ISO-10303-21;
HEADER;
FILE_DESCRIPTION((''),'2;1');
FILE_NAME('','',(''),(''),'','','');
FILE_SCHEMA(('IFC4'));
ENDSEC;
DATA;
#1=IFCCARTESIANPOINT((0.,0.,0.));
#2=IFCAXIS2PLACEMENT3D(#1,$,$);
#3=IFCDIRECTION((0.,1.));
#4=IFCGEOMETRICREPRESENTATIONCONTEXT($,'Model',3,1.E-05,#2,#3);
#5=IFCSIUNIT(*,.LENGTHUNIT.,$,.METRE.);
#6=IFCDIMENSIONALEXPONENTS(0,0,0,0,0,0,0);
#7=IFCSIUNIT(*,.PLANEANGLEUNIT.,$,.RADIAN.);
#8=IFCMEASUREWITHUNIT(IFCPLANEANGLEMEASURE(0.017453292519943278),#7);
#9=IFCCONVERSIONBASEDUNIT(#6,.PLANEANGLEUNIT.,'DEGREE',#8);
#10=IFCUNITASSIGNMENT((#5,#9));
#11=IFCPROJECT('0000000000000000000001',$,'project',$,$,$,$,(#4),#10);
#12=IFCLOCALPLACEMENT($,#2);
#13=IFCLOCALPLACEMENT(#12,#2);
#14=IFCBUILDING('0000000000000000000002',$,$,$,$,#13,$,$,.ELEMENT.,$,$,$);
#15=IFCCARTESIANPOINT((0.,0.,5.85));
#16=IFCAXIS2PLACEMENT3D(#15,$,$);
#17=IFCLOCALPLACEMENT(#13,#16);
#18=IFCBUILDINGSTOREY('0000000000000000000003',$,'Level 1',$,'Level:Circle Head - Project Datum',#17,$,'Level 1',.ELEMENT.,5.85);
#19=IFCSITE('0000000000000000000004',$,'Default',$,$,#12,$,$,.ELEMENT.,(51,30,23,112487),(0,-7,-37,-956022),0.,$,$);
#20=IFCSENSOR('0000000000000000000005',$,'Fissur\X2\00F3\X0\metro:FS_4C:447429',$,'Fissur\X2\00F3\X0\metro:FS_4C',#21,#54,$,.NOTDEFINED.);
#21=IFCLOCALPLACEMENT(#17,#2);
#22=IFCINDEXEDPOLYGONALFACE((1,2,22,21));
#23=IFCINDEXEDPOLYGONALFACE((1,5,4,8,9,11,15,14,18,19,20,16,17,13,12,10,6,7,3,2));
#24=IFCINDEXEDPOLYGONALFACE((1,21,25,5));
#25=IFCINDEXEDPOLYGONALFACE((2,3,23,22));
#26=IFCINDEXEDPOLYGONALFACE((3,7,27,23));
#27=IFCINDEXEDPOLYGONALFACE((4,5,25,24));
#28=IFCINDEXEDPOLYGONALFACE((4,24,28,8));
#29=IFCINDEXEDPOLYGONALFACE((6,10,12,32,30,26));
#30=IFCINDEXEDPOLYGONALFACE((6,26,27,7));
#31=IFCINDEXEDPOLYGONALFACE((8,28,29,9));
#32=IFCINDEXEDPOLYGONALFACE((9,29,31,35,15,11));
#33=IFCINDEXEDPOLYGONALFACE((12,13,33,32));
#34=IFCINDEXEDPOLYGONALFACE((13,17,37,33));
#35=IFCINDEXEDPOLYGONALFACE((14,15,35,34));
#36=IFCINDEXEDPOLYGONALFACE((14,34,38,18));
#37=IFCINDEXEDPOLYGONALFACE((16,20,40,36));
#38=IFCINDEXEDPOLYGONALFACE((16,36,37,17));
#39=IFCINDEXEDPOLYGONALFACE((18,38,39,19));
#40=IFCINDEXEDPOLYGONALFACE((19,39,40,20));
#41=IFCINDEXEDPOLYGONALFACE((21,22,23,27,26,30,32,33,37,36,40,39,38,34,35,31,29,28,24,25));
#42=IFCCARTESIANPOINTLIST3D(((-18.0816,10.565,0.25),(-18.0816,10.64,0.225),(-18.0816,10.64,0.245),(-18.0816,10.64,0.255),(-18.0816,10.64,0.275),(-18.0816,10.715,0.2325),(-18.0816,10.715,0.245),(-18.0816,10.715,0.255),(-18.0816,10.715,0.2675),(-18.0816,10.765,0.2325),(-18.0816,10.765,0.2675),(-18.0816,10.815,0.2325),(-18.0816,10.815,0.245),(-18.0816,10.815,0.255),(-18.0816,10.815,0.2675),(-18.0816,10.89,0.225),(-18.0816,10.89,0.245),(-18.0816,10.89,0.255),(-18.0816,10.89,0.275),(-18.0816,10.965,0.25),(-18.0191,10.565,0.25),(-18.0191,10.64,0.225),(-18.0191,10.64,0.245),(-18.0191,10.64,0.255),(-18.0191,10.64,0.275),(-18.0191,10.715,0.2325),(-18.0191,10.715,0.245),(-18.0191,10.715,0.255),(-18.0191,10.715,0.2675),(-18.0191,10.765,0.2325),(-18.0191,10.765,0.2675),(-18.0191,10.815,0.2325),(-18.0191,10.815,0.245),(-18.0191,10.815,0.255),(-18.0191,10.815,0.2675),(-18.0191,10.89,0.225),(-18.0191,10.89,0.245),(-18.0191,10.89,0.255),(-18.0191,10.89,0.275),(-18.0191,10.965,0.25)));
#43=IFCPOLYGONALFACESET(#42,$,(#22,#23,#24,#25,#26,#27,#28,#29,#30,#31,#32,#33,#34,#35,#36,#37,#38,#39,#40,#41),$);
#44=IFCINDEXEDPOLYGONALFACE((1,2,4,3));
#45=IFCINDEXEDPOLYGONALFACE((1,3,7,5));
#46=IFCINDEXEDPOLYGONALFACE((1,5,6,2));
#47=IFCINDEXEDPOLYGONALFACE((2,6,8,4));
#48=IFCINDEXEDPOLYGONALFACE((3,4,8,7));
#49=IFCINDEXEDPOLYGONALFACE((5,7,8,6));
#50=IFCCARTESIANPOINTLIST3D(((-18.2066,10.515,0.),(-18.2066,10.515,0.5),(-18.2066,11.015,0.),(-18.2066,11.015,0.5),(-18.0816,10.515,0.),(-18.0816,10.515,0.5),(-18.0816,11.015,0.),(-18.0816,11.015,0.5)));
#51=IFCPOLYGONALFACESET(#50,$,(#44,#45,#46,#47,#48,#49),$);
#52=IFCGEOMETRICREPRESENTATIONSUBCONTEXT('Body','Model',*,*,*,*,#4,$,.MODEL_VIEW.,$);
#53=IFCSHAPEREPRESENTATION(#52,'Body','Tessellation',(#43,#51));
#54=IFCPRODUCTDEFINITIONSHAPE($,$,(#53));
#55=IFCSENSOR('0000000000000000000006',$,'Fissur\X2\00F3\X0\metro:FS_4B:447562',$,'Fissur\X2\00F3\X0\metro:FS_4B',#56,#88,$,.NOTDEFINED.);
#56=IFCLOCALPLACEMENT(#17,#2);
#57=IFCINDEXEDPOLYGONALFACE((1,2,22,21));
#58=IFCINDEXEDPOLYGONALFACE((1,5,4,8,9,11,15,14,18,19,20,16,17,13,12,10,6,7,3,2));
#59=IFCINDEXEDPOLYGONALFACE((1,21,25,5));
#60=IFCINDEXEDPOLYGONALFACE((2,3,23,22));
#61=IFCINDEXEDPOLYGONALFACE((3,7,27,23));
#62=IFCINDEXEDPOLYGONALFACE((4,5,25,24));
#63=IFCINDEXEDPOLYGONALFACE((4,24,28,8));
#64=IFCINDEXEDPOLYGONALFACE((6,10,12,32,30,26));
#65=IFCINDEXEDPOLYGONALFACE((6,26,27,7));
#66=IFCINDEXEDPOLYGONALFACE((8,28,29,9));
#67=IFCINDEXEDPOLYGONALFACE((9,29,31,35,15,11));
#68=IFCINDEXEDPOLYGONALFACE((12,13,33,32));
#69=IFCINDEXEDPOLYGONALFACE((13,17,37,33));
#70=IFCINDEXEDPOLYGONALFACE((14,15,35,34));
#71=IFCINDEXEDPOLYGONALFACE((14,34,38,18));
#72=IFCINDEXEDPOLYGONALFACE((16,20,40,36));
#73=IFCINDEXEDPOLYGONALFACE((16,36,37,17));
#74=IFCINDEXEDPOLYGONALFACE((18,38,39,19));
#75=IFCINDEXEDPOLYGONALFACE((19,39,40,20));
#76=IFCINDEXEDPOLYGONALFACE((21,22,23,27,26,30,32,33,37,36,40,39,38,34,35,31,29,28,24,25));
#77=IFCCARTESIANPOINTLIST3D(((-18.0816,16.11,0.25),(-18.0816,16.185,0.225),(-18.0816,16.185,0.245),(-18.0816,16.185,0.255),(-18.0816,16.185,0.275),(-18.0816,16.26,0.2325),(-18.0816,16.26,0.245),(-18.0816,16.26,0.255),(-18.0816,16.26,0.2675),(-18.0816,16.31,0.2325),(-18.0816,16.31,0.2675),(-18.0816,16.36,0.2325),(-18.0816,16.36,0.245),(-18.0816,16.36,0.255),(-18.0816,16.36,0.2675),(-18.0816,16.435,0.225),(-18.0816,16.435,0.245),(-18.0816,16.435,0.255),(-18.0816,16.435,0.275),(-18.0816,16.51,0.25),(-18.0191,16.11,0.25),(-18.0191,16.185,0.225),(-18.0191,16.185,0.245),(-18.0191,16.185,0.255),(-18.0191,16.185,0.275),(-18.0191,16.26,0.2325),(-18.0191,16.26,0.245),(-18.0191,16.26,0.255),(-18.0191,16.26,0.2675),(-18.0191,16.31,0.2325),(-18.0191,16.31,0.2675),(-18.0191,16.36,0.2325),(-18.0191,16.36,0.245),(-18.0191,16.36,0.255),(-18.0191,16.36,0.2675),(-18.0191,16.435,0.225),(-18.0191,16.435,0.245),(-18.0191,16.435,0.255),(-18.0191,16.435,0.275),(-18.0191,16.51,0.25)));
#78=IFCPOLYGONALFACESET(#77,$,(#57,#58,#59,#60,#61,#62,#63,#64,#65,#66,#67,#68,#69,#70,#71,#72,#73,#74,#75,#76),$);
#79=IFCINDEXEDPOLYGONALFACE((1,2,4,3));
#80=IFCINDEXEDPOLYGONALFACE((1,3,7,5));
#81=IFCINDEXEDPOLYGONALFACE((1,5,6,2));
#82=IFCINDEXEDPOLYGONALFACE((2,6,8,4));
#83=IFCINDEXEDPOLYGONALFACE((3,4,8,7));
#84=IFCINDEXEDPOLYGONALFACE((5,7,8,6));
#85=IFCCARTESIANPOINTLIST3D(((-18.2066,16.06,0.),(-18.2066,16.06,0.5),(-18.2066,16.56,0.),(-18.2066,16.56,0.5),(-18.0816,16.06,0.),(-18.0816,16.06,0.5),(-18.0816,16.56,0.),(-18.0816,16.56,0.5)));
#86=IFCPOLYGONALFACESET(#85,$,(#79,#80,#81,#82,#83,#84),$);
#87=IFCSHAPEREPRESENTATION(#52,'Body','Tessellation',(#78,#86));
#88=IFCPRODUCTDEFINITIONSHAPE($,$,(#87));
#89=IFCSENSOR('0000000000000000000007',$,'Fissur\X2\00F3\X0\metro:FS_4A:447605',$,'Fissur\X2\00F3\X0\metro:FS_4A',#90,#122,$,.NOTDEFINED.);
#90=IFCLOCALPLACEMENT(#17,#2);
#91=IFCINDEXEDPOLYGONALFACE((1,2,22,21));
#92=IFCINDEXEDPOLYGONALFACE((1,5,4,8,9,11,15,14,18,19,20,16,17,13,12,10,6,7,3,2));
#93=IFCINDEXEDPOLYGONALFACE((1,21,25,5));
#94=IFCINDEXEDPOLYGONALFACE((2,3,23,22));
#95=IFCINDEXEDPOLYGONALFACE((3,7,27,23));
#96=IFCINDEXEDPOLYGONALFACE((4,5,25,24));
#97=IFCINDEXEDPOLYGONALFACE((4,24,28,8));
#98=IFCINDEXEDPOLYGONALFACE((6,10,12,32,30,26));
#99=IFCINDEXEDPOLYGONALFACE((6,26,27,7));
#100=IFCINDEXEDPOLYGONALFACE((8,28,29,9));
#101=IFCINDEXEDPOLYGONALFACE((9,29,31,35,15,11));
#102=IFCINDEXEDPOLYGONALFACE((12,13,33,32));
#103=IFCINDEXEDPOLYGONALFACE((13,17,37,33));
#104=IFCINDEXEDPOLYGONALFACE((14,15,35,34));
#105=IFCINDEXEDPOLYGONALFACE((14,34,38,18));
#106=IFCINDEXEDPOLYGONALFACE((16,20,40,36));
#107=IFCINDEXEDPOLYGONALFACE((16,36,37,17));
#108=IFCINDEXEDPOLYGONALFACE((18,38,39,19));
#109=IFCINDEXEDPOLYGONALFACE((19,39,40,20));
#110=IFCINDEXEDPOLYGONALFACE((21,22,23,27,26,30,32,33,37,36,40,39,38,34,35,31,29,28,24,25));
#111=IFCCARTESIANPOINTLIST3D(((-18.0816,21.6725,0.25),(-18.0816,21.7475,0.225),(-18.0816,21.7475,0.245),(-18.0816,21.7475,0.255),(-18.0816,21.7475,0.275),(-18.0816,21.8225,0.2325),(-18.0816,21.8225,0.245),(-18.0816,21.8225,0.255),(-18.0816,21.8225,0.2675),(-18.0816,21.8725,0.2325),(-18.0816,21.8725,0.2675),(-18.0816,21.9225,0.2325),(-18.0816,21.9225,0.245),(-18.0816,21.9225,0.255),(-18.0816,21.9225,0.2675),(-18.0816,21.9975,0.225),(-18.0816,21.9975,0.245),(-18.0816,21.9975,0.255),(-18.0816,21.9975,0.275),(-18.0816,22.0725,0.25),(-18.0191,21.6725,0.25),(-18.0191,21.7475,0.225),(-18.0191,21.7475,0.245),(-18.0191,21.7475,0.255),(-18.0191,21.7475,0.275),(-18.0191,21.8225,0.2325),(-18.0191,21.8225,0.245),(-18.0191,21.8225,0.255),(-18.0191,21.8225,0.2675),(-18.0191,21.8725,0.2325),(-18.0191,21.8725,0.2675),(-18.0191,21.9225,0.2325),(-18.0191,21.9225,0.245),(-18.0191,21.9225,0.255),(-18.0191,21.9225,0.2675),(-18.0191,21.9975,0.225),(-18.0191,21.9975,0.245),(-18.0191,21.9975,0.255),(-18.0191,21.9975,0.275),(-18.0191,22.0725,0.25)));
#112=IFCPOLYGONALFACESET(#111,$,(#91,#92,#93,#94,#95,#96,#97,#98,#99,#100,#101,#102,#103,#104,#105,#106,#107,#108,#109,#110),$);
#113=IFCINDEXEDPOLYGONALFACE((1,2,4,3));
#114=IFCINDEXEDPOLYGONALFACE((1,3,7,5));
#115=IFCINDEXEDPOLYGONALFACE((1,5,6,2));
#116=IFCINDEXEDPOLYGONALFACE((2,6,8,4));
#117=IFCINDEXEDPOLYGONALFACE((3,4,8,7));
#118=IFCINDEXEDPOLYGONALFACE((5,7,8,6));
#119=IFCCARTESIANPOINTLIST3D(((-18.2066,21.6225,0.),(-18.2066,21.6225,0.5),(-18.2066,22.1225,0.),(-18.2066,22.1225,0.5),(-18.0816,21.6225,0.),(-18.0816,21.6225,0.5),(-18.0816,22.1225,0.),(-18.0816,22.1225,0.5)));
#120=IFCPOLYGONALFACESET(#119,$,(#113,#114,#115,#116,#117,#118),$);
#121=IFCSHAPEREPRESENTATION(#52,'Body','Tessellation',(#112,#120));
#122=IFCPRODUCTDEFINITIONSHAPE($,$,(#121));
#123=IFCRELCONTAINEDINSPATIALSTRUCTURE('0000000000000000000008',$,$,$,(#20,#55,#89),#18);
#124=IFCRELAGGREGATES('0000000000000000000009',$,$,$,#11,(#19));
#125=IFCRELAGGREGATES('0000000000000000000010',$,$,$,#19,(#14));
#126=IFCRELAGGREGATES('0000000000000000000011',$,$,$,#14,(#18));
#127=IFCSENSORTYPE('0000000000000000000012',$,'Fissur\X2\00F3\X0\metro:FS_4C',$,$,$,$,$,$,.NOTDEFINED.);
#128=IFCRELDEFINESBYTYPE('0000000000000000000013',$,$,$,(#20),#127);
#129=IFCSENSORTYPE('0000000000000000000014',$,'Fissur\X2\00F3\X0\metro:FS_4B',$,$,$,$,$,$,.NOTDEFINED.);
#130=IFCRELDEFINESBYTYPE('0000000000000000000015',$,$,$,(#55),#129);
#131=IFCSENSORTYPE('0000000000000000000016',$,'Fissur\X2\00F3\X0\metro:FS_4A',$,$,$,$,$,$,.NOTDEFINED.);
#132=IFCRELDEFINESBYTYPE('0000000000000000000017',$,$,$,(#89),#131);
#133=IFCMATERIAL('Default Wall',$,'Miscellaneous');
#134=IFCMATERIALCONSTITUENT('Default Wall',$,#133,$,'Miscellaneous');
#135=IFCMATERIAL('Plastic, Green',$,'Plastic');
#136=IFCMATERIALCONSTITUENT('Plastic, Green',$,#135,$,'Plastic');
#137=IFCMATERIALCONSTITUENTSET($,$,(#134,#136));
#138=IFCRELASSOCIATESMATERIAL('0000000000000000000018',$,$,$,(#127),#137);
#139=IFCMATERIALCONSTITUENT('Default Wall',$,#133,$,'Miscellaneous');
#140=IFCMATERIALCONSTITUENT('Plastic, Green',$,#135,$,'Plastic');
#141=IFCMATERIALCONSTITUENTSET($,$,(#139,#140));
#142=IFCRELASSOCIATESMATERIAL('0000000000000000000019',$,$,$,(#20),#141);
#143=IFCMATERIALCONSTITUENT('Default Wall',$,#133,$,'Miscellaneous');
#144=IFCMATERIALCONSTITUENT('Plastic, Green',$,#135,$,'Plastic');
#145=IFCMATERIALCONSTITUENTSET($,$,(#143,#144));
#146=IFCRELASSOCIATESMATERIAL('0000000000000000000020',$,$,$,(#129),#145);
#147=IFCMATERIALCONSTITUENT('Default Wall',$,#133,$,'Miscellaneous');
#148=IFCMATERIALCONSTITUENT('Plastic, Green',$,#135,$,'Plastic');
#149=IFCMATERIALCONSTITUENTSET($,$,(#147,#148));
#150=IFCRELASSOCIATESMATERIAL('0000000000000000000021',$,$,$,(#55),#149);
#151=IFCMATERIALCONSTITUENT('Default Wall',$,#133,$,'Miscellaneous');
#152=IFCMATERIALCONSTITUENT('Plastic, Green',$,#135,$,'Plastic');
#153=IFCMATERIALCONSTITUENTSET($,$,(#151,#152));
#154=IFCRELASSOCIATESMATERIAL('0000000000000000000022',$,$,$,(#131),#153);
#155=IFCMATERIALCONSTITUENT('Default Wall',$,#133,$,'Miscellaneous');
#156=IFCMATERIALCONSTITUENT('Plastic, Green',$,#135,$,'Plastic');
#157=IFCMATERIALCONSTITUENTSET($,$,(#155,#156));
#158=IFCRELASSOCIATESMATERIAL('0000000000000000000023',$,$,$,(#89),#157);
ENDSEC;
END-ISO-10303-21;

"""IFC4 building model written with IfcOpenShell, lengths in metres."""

from ifc_helpers import new_model, entity, si_unit, converted_unit, direction, frame, origin, place, context, subcontext, project, spatial, indexed_curve, outline, extrude, source, transform, mapped, material, constituent, constituent_set, type_object, type_shapes, element, save


model = new_model("IFC4")

# Units and contexts
model_context = context("Model", 3, precision=1e-05, world=origin(), true_north=direction((0.0, 1.0)))
body_context = subcontext(model_context, "Body", "Model", "MODEL_VIEW")
ifc_project = project(units=[si_unit("LENGTHUNIT", "METRE"), converted_unit("PLANEANGLEUNIT", "DEGREE", entity("IfcPlaneAngleMeasure", 0.017453292519943278), si_unit("PLANEANGLEUNIT", "RADIAN"), dimensions=[0, 0, 0, 0, 0, 0, 0])], contexts=[model_context])

# Site, building, storey
site_placement = place(None, origin())
site = spatial("IfcSite", under=ifc_project, at=site_placement, Name="Default", CompositionType="ELEMENT", RefLatitude=(51, 30, 23, 112487), RefLongitude=(0, -7, -37, -956022), RefElevation=0.0)
building_placement = place(site_placement, origin())
building = spatial("IfcBuilding", under=site, at=building_placement, CompositionType="ELEMENT")
storey_placement = place(building_placement, frame((0.0, 0.0, 5.85)))
storey = spatial("IfcBuildingStorey", under=building, at=storey_placement, Name="Level 1", ObjectType="Level:Circle Head - Project Datum", LongName="Level 1", CompositionType="ELEMENT", Elevation=5.85)

# Sensors
ifc_material_1 = material(Name="Default Wall", Category="Miscellaneous")
ifc_material_2 = material(Name="Plastic, Green", Category="Plastic")
ifc_constituent_1 = constituent(ifc_material_1, Name="Default Wall", Category="Miscellaneous")
ifc_constituent_2 = constituent(ifc_material_2, Name="Plastic, Green", Category="Plastic")
ifc_constituent_set_1 = constituent_set(constituents=[ifc_constituent_1, ifc_constituent_2])
ifc_constituent_3 = constituent(ifc_material_1, Name="Default Wall", Category="Miscellaneous")
ifc_constituent_4 = constituent(ifc_material_2, Name="Plastic, Green", Category="Plastic")
ifc_constituent_set_2 = constituent_set(constituents=[ifc_constituent_3, ifc_constituent_4])
sensor_type_1 = type_object("IfcSensorType", Name="Fissurómetro:FS_4C", PredefinedType="NOTDEFINED", material=ifc_constituent_set_2)
shared_shape_1 = source(origin(), body_context, "Body", "SweptSolid", [
    extrude(outline(indexed_curve([(-0.025, -0.125), (0.0, -0.2), (0.025, -0.125), (0.005, -0.125), (0.005, -0.05), (0.0175, -0.05), (0.0175, 0.0), (0.0175, 0.05), (0.005, 0.05), (0.005, 0.125), (0.025, 0.125), (0.0, 0.2), (-0.025, 0.125), (-0.005, 0.125), (-0.005, 0.05), (-0.0175, 0.05), (-0.0175, 0.0), (-0.0175, -0.05), (-0.005, -0.05), (-0.005, -0.125), (-0.025, -0.125)], self_intersect=False)), frame((0.0, -0.125, 0.25), z_axis=(0.0, -1.0, 0.0), x_axis=(0.0, 0.0, -1.0)), (0.0, 0.0, -1.0), 0.0625),
    extrude(outline(indexed_curve([(-0.25, -0.0625), (0.25, -0.0625), (0.25, 0.0625), (-0.25, 0.0625), (-0.25, -0.0625)], self_intersect=False)), frame((0.0, 0.0, 0.0), z_axis=(0.0, 0.0, 1.0), x_axis=(-1.0, 0.0, 0.0)), (0.0, 0.0, 1.0), 0.5),
])
type_shapes(sensor_type_1, [shared_shape_1])
sensor_1_placement = place(storey_placement, frame((-18.1441, 10.765, 0.0), z_axis=(0.0, 0.0, 1.0), x_axis=(0.0, 1.0, 0.0)))
element("IfcSensor", 1, at=sensor_1_placement, inside=storey, type_object=sensor_type_1, material=ifc_constituent_set_1, Name="Fissurómetro:FS_4C:447429", ObjectType="Fissurómetro:FS_4C", PredefinedType="NOTDEFINED", context=body_context, shape_type="MappedRepresentation", body=[
    mapped(shared_shape_1, transform((0.0, 0.0, 0.0), scale=1.0)),
])
ifc_constituent_5 = constituent(ifc_material_1, Name="Default Wall", Category="Miscellaneous")
ifc_constituent_6 = constituent(ifc_material_2, Name="Plastic, Green", Category="Plastic")
ifc_constituent_set_3 = constituent_set(constituents=[ifc_constituent_5, ifc_constituent_6])
ifc_constituent_7 = constituent(ifc_material_1, Name="Default Wall", Category="Miscellaneous")
ifc_constituent_8 = constituent(ifc_material_2, Name="Plastic, Green", Category="Plastic")
ifc_constituent_set_4 = constituent_set(constituents=[ifc_constituent_7, ifc_constituent_8])
sensor_type_2 = type_object("IfcSensorType", Name="Fissurómetro:FS_4B", PredefinedType="NOTDEFINED", material=ifc_constituent_set_4)
shared_shape_2 = source(origin(), body_context, "Body", "SweptSolid", [
    extrude(outline(indexed_curve([(-0.025, -0.125), (0.0, -0.2), (0.025, -0.125), (0.005, -0.125), (0.005, -0.05), (0.0175, -0.05), (0.0175, 0.0), (0.0175, 0.05), (0.005, 0.05), (0.005, 0.125), (0.025, 0.125), (0.0, 0.2), (-0.025, 0.125), (-0.005, 0.125), (-0.005, 0.05), (-0.0175, 0.05), (-0.0175, 0.0), (-0.0175, -0.05), (-0.005, -0.05), (-0.005, -0.125), (-0.025, -0.125)], self_intersect=False)), frame((0.0, -0.125, 0.25), z_axis=(0.0, -1.0, 0.0), x_axis=(0.0, 0.0, -1.0)), (0.0, 0.0, -1.0), 0.0625),
    extrude(outline(indexed_curve([(-0.25, -0.0625), (0.25, -0.0625), (0.25, 0.0625), (-0.25, 0.0625), (-0.25, -0.0625)], self_intersect=False)), frame((0.0, 0.0, 0.0), z_axis=(0.0, 0.0, 1.0), x_axis=(-1.0, 0.0, 0.0)), (0.0, 0.0, 1.0), 0.5),
])
type_shapes(sensor_type_2, [shared_shape_2])
sensor_2_placement = place(storey_placement, frame((-18.1441, 16.31, 0.0), z_axis=(0.0, 0.0, 1.0), x_axis=(0.0, 1.0, 0.0)))
element("IfcSensor", 2, at=sensor_2_placement, inside=storey, type_object=sensor_type_2, material=ifc_constituent_set_3, Name="Fissurómetro:FS_4B:447562", ObjectType="Fissurómetro:FS_4B", PredefinedType="NOTDEFINED", context=body_context, shape_type="MappedRepresentation", body=[
    mapped(shared_shape_2, transform((0.0, 0.0, 0.0), scale=1.0)),
])
ifc_constituent_9 = constituent(ifc_material_1, Name="Default Wall", Category="Miscellaneous")
ifc_constituent_10 = constituent(ifc_material_2, Name="Plastic, Green", Category="Plastic")
ifc_constituent_set_5 = constituent_set(constituents=[ifc_constituent_9, ifc_constituent_10])
ifc_constituent_11 = constituent(ifc_material_1, Name="Default Wall", Category="Miscellaneous")
ifc_constituent_12 = constituent(ifc_material_2, Name="Plastic, Green", Category="Plastic")
ifc_constituent_set_6 = constituent_set(constituents=[ifc_constituent_11, ifc_constituent_12])
sensor_type_3 = type_object("IfcSensorType", Name="Fissurómetro:FS_4A", PredefinedType="NOTDEFINED", material=ifc_constituent_set_6)
shared_shape_3 = source(origin(), body_context, "Body", "SweptSolid", [
    extrude(outline(indexed_curve([(-0.025, -0.125), (0.0, -0.2), (0.025, -0.125), (0.005, -0.125), (0.005, -0.05), (0.0175, -0.05), (0.0175, 0.0), (0.0175, 0.05), (0.005, 0.05), (0.005, 0.125), (0.025, 0.125), (0.0, 0.2), (-0.025, 0.125), (-0.005, 0.125), (-0.005, 0.05), (-0.0175, 0.05), (-0.0175, 0.0), (-0.0175, -0.05), (-0.005, -0.05), (-0.005, -0.125), (-0.025, -0.125)], self_intersect=False)), frame((0.0, -0.125, 0.25), z_axis=(0.0, -1.0, 0.0), x_axis=(0.0, 0.0, -1.0)), (0.0, 0.0, -1.0), 0.0625),
    extrude(outline(indexed_curve([(-0.25, -0.0625), (0.25, -0.0625), (0.25, 0.0625), (-0.25, 0.0625), (-0.25, -0.0625)], self_intersect=False)), frame((0.0, 0.0, 0.0), z_axis=(0.0, 0.0, 1.0), x_axis=(-1.0, 0.0, 0.0)), (0.0, 0.0, 1.0), 0.5),
])
type_shapes(sensor_type_3, [shared_shape_3])
sensor_3_placement = place(storey_placement, frame((-18.1441, 21.8725, 0.0), z_axis=(0.0, 0.0, 1.0), x_axis=(0.0, 1.0, 0.0)))
element("IfcSensor", 3, at=sensor_3_placement, inside=storey, type_object=sensor_type_3, material=ifc_constituent_set_5, Name="Fissurómetro:FS_4A:447605", ObjectType="Fissurómetro:FS_4A", PredefinedType="NOTDEFINED", context=body_context, shape_type="MappedRepresentation", body=[
    mapped(shared_shape_3, transform((0.0, 0.0, 0.0), scale=1.0)),
])

save(model, "model.ifc")
